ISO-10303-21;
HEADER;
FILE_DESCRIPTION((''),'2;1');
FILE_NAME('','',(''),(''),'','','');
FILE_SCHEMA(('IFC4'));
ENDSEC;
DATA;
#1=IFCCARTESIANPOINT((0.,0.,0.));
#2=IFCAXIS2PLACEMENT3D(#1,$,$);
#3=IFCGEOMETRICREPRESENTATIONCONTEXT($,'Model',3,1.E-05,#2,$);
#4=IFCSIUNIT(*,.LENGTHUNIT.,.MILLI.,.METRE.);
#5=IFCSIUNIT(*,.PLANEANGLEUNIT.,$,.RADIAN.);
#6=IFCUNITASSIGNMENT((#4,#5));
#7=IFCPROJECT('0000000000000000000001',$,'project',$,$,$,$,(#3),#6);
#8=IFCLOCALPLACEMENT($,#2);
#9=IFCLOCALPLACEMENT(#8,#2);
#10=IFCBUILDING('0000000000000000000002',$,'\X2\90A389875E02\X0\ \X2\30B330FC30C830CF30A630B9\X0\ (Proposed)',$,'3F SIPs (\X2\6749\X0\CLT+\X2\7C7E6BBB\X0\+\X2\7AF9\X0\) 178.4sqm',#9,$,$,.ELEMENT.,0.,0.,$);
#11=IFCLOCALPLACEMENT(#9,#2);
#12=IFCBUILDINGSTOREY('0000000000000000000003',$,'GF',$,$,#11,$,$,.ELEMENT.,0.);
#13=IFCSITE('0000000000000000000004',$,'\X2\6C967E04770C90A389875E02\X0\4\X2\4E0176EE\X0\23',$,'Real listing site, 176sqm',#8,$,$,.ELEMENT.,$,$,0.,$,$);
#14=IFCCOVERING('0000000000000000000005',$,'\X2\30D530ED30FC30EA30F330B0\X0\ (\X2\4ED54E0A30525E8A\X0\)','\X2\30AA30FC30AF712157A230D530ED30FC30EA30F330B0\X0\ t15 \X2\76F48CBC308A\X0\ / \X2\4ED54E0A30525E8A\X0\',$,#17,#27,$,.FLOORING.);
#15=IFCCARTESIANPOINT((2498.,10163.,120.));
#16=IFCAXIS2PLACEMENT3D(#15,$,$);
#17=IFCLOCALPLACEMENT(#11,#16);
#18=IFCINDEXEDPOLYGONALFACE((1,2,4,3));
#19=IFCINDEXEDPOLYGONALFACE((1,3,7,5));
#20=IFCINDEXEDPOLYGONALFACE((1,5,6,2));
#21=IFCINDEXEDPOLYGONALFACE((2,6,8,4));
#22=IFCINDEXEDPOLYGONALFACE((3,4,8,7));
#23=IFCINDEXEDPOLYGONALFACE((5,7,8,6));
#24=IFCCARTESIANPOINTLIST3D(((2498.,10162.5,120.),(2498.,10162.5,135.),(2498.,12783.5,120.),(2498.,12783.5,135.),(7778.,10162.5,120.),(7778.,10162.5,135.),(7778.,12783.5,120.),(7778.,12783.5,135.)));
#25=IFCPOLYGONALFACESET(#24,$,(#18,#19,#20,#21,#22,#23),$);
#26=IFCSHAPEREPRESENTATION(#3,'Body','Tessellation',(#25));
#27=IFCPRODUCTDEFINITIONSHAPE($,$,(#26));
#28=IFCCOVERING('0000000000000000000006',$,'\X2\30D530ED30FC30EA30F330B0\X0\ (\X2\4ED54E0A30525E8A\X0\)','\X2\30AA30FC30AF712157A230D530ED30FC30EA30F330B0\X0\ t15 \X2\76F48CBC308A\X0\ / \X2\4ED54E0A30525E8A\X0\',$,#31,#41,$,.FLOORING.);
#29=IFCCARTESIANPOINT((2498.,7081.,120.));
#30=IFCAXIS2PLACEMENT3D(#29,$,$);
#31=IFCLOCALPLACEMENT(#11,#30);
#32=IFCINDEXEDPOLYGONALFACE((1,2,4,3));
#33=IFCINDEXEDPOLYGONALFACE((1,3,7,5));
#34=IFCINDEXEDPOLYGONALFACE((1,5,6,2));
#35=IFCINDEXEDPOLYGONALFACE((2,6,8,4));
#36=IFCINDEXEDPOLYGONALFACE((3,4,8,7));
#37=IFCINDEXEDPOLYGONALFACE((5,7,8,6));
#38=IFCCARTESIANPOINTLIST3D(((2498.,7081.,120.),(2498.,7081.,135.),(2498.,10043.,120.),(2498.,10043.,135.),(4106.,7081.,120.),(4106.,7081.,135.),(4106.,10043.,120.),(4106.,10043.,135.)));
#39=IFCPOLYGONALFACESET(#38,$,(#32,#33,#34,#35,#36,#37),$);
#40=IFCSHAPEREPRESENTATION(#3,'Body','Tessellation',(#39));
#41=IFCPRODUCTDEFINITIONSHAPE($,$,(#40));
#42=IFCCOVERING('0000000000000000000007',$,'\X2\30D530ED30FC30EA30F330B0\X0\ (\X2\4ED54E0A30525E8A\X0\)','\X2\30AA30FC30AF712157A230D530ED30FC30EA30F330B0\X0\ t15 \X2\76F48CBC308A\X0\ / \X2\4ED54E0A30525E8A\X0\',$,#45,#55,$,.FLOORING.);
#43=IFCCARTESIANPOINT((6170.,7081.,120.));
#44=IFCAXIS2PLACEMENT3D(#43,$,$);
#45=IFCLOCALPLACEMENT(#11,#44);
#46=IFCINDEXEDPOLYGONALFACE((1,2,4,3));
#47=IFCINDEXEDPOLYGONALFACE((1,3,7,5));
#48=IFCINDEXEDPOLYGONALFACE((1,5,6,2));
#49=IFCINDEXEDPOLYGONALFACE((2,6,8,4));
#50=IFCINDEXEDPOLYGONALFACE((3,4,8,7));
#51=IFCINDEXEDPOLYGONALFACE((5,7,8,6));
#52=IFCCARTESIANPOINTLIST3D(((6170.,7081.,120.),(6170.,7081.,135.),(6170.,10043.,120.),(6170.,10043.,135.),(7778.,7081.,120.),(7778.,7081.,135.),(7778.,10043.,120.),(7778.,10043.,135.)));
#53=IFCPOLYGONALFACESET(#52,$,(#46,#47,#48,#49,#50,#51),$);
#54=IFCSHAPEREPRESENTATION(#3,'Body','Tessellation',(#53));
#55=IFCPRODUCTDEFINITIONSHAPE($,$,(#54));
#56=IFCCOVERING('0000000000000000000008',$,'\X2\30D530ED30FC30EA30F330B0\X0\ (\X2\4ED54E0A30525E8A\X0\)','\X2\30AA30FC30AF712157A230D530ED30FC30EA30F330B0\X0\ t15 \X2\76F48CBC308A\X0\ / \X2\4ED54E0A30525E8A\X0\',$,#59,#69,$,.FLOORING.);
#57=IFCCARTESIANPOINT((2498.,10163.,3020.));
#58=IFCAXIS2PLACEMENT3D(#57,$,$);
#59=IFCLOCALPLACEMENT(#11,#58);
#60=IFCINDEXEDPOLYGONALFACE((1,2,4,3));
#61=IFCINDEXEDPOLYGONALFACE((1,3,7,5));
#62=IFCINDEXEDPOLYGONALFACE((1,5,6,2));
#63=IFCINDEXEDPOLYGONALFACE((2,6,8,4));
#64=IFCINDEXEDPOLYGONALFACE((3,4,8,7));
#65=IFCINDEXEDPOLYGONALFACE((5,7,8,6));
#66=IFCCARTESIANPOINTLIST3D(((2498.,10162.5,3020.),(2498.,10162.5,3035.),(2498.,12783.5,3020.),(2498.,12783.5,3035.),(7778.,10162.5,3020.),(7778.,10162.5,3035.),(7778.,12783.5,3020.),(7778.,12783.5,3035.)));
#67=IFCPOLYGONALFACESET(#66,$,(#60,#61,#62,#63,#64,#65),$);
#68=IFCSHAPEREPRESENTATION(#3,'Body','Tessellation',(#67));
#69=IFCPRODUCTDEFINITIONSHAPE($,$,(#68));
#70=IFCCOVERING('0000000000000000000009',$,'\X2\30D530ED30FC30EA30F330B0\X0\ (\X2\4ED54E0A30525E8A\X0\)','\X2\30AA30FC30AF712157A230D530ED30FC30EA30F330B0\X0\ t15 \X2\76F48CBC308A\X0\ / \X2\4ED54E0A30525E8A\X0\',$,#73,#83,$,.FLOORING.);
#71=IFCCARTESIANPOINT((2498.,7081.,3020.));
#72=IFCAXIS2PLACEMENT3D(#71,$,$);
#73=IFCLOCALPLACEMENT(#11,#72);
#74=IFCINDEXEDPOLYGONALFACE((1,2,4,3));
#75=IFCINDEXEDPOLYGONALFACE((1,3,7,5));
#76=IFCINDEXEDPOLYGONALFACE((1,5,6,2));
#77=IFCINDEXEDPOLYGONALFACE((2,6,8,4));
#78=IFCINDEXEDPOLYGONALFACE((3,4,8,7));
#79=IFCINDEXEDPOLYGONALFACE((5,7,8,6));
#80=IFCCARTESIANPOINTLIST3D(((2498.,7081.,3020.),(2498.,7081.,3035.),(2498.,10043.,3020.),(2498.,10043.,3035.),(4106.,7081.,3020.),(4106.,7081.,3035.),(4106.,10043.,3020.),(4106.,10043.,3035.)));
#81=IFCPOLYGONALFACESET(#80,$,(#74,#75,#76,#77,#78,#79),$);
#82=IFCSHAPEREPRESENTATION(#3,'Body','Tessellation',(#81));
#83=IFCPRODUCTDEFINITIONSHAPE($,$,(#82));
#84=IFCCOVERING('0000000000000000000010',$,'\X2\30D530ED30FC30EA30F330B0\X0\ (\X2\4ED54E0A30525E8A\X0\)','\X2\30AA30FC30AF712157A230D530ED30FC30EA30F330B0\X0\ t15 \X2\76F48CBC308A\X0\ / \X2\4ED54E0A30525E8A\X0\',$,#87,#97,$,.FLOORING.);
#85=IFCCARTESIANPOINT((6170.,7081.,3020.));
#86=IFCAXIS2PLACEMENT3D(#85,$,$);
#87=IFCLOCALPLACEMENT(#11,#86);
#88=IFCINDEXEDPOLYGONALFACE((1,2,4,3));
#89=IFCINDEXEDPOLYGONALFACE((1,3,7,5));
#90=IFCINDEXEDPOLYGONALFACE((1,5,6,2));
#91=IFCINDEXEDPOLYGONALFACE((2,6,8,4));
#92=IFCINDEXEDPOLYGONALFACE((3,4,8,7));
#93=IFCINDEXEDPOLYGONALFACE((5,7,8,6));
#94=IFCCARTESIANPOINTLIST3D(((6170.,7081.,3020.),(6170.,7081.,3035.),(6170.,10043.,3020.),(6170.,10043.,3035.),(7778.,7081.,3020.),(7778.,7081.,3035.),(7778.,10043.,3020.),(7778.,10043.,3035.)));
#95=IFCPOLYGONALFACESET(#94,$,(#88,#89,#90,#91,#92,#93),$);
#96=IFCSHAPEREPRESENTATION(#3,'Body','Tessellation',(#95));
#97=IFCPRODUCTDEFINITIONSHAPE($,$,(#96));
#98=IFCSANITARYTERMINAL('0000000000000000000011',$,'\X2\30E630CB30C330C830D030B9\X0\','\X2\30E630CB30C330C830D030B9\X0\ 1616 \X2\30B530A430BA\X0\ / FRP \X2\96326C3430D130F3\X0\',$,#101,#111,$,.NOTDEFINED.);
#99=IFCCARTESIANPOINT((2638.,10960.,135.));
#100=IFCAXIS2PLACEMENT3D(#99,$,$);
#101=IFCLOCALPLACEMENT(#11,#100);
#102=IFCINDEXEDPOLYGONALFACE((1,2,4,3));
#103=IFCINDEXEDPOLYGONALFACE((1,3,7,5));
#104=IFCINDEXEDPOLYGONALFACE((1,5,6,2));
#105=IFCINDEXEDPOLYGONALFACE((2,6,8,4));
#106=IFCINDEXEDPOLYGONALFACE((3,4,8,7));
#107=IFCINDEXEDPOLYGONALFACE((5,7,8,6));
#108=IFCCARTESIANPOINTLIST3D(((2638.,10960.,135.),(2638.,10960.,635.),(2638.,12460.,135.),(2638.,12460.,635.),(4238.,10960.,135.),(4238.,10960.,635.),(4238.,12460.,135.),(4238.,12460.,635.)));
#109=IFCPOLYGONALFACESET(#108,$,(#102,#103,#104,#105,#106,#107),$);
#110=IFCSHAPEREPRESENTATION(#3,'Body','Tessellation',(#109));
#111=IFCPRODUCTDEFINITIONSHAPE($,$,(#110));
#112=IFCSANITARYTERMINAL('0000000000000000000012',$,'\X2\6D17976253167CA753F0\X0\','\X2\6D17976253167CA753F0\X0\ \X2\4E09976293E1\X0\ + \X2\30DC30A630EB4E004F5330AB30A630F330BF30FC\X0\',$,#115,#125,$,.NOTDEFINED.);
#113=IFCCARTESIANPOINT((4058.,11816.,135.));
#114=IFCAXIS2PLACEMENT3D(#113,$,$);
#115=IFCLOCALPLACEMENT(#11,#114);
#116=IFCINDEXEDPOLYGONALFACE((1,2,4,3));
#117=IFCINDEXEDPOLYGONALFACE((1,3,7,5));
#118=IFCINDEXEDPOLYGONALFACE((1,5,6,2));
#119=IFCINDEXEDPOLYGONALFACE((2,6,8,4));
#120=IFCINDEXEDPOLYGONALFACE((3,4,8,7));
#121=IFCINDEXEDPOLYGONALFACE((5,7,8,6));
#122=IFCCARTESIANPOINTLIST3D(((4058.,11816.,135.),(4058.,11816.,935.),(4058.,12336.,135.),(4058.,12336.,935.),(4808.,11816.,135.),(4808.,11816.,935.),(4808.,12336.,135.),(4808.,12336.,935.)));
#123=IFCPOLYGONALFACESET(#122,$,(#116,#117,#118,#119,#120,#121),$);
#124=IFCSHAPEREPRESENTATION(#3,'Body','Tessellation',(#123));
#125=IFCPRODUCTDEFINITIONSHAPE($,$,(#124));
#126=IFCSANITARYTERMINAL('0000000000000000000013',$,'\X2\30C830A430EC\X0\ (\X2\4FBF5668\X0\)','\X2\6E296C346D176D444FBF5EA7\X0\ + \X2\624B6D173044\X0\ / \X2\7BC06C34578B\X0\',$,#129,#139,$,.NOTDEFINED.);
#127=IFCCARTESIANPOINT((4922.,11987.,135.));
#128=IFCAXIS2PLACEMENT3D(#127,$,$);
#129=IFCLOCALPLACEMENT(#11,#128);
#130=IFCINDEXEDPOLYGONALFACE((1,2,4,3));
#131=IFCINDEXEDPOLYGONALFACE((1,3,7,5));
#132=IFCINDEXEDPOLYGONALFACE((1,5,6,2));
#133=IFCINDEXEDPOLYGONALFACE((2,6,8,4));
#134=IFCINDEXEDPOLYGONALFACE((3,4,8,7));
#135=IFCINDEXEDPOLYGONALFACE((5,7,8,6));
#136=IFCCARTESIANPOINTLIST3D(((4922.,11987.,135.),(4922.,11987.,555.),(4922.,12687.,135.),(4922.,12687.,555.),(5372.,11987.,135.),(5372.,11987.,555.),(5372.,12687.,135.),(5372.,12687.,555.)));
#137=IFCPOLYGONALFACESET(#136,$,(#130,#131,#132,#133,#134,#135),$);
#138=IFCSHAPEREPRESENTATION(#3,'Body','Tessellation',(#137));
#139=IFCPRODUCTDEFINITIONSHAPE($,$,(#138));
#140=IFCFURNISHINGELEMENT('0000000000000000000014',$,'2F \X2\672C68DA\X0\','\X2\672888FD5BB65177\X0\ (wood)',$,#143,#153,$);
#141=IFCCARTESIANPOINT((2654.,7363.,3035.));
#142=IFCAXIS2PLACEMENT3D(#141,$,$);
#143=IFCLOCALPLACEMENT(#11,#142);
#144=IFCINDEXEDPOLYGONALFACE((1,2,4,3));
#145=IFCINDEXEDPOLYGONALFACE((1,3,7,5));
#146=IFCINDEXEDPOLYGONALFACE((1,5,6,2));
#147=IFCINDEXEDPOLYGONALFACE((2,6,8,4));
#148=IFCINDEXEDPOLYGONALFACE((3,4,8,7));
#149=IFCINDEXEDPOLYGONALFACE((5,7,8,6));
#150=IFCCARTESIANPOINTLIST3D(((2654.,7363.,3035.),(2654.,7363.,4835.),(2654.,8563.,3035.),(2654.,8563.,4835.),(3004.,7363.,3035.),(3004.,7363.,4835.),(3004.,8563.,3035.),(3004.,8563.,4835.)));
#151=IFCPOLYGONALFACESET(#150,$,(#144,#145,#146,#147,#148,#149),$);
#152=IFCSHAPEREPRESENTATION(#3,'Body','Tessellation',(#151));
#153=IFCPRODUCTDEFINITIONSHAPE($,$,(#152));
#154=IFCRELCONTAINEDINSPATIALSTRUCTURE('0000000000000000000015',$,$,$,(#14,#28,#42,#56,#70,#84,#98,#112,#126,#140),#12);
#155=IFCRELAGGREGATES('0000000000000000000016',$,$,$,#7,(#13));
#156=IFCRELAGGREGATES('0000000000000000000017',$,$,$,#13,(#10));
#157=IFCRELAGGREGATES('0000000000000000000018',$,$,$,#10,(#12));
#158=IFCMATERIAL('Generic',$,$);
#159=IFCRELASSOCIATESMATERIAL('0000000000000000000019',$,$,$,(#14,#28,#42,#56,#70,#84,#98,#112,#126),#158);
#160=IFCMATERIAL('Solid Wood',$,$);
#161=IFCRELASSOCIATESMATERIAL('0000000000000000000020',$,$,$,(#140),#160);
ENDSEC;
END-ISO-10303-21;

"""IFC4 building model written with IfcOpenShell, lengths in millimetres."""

from ifc_helpers import new_model, si_unit, frame, frame_2d, origin, place, context, project, spatial, rectangle, extrude, material, element, save


model = new_model("IFC4")

# Units and contexts
model_context = context("Model", 3, precision=1e-05, world=origin())
ifc_project = project(units=[si_unit("LENGTHUNIT", "METRE", prefix="MILLI"), si_unit("PLANEANGLEUNIT", "RADIAN")], contexts=[model_context])

# Site, building, storey
site_placement = place(None, origin())
site = spatial("IfcSite", under=ifc_project, at=site_placement, Name="沖縄県那覇市4丁目23", ObjectType="Real listing site, 176sqm", CompositionType="ELEMENT", RefElevation=0.0)
building_placement = place(site_placement, origin())
building = spatial("IfcBuilding", under=site, at=building_placement, Name="那覇市 コートハウス (Proposed)", ObjectType="3F SIPs (杉CLT+籾殻+竹) 178.4sqm", CompositionType="ELEMENT", ElevationOfRefHeight=0.0, ElevationOfTerrain=0.0)
storey_placement = place(building_placement, origin())
storey = spatial("IfcBuildingStorey", under=building, at=storey_placement, Name="GF", CompositionType="ELEMENT", Elevation=0.0)

# Shared definitions
ifc_material_1 = material(Name="Solid Wood")

# Coverings
ifc_material_2 = material(Name="Generic")
covering_1_placement = place(storey_placement, frame((2498.0, 10163.0, 120.0)))
element("IfcCovering", 1, at=covering_1_placement, inside=storey, material=ifc_material_2, Name="フローリング (仕上げ床)", Description="オーク無垢フローリング t15 直貼り / 仕上げ床", PredefinedType="FLOORING", context=model_context, shape_type="SweptSolid", body=[
    extrude(rectangle(XDim=5280.0, YDim=2621.0, at=frame_2d((2640.0, 1310.0))), frame((2498.0, 10163.0, 120.0)), (0.0, 0.0, 1.0), 15.0),
])
covering_2_placement = place(storey_placement, frame((2498.0, 7081.0, 120.0)))
element("IfcCovering", 2, at=covering_2_placement, inside=storey, material=ifc_material_2, Name="フローリング (仕上げ床)", Description="オーク無垢フローリング t15 直貼り / 仕上げ床", PredefinedType="FLOORING", context=model_context, shape_type="SweptSolid", body=[
    extrude(rectangle(XDim=1608.0, YDim=2962.0, at=frame_2d((804.0, 1481.0))), frame((2498.0, 7081.0, 120.0)), (0.0, 0.0, 1.0), 15.0),
])
covering_3_placement = place(storey_placement, frame((6170.0, 7081.0, 120.0)))
element("IfcCovering", 3, at=covering_3_placement, inside=storey, material=ifc_material_2, Name="フローリング (仕上げ床)", Description="オーク無垢フローリング t15 直貼り / 仕上げ床", PredefinedType="FLOORING", context=model_context, shape_type="SweptSolid", body=[
    extrude(rectangle(XDim=1608.0, YDim=2962.0, at=frame_2d((804.0, 1481.0))), frame((6170.0, 7081.0, 120.0)), (0.0, 0.0, 1.0), 15.0),
])
covering_4_placement = place(storey_placement, frame((2498.0, 10163.0, 3020.0)))
element("IfcCovering", 4, at=covering_4_placement, inside=storey, material=ifc_material_2, Name="フローリング (仕上げ床)", Description="オーク無垢フローリング t15 直貼り / 仕上げ床", PredefinedType="FLOORING", context=model_context, shape_type="SweptSolid", body=[
    extrude(rectangle(XDim=5280.0, YDim=2621.0, at=frame_2d((2640.0, 1310.0))), frame((2498.0, 10163.0, 3020.0)), (0.0, 0.0, 1.0), 15.0),
])
covering_5_placement = place(storey_placement, frame((2498.0, 7081.0, 3020.0)))
element("IfcCovering", 5, at=covering_5_placement, inside=storey, material=ifc_material_2, Name="フローリング (仕上げ床)", Description="オーク無垢フローリング t15 直貼り / 仕上げ床", PredefinedType="FLOORING", context=model_context, shape_type="SweptSolid", body=[
    extrude(rectangle(XDim=1608.0, YDim=2962.0, at=frame_2d((804.0, 1481.0))), frame((2498.0, 7081.0, 3020.0)), (0.0, 0.0, 1.0), 15.0),
])
covering_6_placement = place(storey_placement, frame((6170.0, 7081.0, 3020.0)))
element("IfcCovering", 6, at=covering_6_placement, inside=storey, material=ifc_material_2, Name="フローリング (仕上げ床)", Description="オーク無垢フローリング t15 直貼り / 仕上げ床", PredefinedType="FLOORING", context=model_context, shape_type="SweptSolid", body=[
    extrude(rectangle(XDim=1608.0, YDim=2962.0, at=frame_2d((804.0, 1481.0))), frame((6170.0, 7081.0, 3020.0)), (0.0, 0.0, 1.0), 15.0),
])

# Sanitary terminals
sanitary_terminal_1_placement = place(storey_placement, frame((2638.0, 10960.0, 135.0)))
element("IfcSanitaryTerminal", 7, at=sanitary_terminal_1_placement, inside=storey, material=ifc_material_2, Name="ユニットバス", Description="ユニットバス 1616 サイズ / FRP 防水パン", PredefinedType="NOTDEFINED", context=model_context, shape_type="SweptSolid", body=[
    extrude(rectangle(XDim=1600.0, YDim=1500.0, at=frame_2d((800.0, 750.0))), frame((2638.0, 10960.0, 135.0)), (0.0, 0.0, 1.0), 500.0),
])
sanitary_terminal_2_placement = place(storey_placement, frame((4058.0, 11816.0, 135.0)))
element("IfcSanitaryTerminal", 8, at=sanitary_terminal_2_placement, inside=storey, material=ifc_material_2, Name="洗面化粧台", Description="洗面化粧台 三面鏡 + ボウル一体カウンター", PredefinedType="NOTDEFINED", context=model_context, shape_type="SweptSolid", body=[
    extrude(rectangle(XDim=750.0, YDim=520.0, at=frame_2d((375.0, 260.0))), frame((4058.0, 11816.0, 135.0)), (0.0, 0.0, 1.0), 800.0),
])
sanitary_terminal_3_placement = place(storey_placement, frame((4922.0, 11987.0, 135.0)))
element("IfcSanitaryTerminal", 9, at=sanitary_terminal_3_placement, inside=storey, material=ifc_material_2, Name="トイレ (便器)", Description="温水洗浄便座 + 手洗い / 節水型", PredefinedType="NOTDEFINED", context=model_context, shape_type="SweptSolid", body=[
    extrude(rectangle(XDim=450.0, YDim=700.0, at=frame_2d((225.0, 350.0))), frame((4922.0, 11987.0, 135.0)), (0.0, 0.0, 1.0), 420.0),
])

# Furnishing element
furnishing_placement = place(storey_placement, frame((2654.0, 7363.0, 3035.0)))
element("IfcFurnishingElement", 10, at=furnishing_placement, inside=storey, material=ifc_material_1, Name="2F 本棚", Description="木製家具 (wood)", context=model_context, shape_type="SweptSolid", body=[
    extrude(rectangle(XDim=350.0, YDim=1200.0, at=frame_2d((175.0, 600.0))), frame((2654.0, 7363.0, 3035.0)), (0.0, 0.0, 1.0), 1800.0),
])

save(model, "model.ifc")
